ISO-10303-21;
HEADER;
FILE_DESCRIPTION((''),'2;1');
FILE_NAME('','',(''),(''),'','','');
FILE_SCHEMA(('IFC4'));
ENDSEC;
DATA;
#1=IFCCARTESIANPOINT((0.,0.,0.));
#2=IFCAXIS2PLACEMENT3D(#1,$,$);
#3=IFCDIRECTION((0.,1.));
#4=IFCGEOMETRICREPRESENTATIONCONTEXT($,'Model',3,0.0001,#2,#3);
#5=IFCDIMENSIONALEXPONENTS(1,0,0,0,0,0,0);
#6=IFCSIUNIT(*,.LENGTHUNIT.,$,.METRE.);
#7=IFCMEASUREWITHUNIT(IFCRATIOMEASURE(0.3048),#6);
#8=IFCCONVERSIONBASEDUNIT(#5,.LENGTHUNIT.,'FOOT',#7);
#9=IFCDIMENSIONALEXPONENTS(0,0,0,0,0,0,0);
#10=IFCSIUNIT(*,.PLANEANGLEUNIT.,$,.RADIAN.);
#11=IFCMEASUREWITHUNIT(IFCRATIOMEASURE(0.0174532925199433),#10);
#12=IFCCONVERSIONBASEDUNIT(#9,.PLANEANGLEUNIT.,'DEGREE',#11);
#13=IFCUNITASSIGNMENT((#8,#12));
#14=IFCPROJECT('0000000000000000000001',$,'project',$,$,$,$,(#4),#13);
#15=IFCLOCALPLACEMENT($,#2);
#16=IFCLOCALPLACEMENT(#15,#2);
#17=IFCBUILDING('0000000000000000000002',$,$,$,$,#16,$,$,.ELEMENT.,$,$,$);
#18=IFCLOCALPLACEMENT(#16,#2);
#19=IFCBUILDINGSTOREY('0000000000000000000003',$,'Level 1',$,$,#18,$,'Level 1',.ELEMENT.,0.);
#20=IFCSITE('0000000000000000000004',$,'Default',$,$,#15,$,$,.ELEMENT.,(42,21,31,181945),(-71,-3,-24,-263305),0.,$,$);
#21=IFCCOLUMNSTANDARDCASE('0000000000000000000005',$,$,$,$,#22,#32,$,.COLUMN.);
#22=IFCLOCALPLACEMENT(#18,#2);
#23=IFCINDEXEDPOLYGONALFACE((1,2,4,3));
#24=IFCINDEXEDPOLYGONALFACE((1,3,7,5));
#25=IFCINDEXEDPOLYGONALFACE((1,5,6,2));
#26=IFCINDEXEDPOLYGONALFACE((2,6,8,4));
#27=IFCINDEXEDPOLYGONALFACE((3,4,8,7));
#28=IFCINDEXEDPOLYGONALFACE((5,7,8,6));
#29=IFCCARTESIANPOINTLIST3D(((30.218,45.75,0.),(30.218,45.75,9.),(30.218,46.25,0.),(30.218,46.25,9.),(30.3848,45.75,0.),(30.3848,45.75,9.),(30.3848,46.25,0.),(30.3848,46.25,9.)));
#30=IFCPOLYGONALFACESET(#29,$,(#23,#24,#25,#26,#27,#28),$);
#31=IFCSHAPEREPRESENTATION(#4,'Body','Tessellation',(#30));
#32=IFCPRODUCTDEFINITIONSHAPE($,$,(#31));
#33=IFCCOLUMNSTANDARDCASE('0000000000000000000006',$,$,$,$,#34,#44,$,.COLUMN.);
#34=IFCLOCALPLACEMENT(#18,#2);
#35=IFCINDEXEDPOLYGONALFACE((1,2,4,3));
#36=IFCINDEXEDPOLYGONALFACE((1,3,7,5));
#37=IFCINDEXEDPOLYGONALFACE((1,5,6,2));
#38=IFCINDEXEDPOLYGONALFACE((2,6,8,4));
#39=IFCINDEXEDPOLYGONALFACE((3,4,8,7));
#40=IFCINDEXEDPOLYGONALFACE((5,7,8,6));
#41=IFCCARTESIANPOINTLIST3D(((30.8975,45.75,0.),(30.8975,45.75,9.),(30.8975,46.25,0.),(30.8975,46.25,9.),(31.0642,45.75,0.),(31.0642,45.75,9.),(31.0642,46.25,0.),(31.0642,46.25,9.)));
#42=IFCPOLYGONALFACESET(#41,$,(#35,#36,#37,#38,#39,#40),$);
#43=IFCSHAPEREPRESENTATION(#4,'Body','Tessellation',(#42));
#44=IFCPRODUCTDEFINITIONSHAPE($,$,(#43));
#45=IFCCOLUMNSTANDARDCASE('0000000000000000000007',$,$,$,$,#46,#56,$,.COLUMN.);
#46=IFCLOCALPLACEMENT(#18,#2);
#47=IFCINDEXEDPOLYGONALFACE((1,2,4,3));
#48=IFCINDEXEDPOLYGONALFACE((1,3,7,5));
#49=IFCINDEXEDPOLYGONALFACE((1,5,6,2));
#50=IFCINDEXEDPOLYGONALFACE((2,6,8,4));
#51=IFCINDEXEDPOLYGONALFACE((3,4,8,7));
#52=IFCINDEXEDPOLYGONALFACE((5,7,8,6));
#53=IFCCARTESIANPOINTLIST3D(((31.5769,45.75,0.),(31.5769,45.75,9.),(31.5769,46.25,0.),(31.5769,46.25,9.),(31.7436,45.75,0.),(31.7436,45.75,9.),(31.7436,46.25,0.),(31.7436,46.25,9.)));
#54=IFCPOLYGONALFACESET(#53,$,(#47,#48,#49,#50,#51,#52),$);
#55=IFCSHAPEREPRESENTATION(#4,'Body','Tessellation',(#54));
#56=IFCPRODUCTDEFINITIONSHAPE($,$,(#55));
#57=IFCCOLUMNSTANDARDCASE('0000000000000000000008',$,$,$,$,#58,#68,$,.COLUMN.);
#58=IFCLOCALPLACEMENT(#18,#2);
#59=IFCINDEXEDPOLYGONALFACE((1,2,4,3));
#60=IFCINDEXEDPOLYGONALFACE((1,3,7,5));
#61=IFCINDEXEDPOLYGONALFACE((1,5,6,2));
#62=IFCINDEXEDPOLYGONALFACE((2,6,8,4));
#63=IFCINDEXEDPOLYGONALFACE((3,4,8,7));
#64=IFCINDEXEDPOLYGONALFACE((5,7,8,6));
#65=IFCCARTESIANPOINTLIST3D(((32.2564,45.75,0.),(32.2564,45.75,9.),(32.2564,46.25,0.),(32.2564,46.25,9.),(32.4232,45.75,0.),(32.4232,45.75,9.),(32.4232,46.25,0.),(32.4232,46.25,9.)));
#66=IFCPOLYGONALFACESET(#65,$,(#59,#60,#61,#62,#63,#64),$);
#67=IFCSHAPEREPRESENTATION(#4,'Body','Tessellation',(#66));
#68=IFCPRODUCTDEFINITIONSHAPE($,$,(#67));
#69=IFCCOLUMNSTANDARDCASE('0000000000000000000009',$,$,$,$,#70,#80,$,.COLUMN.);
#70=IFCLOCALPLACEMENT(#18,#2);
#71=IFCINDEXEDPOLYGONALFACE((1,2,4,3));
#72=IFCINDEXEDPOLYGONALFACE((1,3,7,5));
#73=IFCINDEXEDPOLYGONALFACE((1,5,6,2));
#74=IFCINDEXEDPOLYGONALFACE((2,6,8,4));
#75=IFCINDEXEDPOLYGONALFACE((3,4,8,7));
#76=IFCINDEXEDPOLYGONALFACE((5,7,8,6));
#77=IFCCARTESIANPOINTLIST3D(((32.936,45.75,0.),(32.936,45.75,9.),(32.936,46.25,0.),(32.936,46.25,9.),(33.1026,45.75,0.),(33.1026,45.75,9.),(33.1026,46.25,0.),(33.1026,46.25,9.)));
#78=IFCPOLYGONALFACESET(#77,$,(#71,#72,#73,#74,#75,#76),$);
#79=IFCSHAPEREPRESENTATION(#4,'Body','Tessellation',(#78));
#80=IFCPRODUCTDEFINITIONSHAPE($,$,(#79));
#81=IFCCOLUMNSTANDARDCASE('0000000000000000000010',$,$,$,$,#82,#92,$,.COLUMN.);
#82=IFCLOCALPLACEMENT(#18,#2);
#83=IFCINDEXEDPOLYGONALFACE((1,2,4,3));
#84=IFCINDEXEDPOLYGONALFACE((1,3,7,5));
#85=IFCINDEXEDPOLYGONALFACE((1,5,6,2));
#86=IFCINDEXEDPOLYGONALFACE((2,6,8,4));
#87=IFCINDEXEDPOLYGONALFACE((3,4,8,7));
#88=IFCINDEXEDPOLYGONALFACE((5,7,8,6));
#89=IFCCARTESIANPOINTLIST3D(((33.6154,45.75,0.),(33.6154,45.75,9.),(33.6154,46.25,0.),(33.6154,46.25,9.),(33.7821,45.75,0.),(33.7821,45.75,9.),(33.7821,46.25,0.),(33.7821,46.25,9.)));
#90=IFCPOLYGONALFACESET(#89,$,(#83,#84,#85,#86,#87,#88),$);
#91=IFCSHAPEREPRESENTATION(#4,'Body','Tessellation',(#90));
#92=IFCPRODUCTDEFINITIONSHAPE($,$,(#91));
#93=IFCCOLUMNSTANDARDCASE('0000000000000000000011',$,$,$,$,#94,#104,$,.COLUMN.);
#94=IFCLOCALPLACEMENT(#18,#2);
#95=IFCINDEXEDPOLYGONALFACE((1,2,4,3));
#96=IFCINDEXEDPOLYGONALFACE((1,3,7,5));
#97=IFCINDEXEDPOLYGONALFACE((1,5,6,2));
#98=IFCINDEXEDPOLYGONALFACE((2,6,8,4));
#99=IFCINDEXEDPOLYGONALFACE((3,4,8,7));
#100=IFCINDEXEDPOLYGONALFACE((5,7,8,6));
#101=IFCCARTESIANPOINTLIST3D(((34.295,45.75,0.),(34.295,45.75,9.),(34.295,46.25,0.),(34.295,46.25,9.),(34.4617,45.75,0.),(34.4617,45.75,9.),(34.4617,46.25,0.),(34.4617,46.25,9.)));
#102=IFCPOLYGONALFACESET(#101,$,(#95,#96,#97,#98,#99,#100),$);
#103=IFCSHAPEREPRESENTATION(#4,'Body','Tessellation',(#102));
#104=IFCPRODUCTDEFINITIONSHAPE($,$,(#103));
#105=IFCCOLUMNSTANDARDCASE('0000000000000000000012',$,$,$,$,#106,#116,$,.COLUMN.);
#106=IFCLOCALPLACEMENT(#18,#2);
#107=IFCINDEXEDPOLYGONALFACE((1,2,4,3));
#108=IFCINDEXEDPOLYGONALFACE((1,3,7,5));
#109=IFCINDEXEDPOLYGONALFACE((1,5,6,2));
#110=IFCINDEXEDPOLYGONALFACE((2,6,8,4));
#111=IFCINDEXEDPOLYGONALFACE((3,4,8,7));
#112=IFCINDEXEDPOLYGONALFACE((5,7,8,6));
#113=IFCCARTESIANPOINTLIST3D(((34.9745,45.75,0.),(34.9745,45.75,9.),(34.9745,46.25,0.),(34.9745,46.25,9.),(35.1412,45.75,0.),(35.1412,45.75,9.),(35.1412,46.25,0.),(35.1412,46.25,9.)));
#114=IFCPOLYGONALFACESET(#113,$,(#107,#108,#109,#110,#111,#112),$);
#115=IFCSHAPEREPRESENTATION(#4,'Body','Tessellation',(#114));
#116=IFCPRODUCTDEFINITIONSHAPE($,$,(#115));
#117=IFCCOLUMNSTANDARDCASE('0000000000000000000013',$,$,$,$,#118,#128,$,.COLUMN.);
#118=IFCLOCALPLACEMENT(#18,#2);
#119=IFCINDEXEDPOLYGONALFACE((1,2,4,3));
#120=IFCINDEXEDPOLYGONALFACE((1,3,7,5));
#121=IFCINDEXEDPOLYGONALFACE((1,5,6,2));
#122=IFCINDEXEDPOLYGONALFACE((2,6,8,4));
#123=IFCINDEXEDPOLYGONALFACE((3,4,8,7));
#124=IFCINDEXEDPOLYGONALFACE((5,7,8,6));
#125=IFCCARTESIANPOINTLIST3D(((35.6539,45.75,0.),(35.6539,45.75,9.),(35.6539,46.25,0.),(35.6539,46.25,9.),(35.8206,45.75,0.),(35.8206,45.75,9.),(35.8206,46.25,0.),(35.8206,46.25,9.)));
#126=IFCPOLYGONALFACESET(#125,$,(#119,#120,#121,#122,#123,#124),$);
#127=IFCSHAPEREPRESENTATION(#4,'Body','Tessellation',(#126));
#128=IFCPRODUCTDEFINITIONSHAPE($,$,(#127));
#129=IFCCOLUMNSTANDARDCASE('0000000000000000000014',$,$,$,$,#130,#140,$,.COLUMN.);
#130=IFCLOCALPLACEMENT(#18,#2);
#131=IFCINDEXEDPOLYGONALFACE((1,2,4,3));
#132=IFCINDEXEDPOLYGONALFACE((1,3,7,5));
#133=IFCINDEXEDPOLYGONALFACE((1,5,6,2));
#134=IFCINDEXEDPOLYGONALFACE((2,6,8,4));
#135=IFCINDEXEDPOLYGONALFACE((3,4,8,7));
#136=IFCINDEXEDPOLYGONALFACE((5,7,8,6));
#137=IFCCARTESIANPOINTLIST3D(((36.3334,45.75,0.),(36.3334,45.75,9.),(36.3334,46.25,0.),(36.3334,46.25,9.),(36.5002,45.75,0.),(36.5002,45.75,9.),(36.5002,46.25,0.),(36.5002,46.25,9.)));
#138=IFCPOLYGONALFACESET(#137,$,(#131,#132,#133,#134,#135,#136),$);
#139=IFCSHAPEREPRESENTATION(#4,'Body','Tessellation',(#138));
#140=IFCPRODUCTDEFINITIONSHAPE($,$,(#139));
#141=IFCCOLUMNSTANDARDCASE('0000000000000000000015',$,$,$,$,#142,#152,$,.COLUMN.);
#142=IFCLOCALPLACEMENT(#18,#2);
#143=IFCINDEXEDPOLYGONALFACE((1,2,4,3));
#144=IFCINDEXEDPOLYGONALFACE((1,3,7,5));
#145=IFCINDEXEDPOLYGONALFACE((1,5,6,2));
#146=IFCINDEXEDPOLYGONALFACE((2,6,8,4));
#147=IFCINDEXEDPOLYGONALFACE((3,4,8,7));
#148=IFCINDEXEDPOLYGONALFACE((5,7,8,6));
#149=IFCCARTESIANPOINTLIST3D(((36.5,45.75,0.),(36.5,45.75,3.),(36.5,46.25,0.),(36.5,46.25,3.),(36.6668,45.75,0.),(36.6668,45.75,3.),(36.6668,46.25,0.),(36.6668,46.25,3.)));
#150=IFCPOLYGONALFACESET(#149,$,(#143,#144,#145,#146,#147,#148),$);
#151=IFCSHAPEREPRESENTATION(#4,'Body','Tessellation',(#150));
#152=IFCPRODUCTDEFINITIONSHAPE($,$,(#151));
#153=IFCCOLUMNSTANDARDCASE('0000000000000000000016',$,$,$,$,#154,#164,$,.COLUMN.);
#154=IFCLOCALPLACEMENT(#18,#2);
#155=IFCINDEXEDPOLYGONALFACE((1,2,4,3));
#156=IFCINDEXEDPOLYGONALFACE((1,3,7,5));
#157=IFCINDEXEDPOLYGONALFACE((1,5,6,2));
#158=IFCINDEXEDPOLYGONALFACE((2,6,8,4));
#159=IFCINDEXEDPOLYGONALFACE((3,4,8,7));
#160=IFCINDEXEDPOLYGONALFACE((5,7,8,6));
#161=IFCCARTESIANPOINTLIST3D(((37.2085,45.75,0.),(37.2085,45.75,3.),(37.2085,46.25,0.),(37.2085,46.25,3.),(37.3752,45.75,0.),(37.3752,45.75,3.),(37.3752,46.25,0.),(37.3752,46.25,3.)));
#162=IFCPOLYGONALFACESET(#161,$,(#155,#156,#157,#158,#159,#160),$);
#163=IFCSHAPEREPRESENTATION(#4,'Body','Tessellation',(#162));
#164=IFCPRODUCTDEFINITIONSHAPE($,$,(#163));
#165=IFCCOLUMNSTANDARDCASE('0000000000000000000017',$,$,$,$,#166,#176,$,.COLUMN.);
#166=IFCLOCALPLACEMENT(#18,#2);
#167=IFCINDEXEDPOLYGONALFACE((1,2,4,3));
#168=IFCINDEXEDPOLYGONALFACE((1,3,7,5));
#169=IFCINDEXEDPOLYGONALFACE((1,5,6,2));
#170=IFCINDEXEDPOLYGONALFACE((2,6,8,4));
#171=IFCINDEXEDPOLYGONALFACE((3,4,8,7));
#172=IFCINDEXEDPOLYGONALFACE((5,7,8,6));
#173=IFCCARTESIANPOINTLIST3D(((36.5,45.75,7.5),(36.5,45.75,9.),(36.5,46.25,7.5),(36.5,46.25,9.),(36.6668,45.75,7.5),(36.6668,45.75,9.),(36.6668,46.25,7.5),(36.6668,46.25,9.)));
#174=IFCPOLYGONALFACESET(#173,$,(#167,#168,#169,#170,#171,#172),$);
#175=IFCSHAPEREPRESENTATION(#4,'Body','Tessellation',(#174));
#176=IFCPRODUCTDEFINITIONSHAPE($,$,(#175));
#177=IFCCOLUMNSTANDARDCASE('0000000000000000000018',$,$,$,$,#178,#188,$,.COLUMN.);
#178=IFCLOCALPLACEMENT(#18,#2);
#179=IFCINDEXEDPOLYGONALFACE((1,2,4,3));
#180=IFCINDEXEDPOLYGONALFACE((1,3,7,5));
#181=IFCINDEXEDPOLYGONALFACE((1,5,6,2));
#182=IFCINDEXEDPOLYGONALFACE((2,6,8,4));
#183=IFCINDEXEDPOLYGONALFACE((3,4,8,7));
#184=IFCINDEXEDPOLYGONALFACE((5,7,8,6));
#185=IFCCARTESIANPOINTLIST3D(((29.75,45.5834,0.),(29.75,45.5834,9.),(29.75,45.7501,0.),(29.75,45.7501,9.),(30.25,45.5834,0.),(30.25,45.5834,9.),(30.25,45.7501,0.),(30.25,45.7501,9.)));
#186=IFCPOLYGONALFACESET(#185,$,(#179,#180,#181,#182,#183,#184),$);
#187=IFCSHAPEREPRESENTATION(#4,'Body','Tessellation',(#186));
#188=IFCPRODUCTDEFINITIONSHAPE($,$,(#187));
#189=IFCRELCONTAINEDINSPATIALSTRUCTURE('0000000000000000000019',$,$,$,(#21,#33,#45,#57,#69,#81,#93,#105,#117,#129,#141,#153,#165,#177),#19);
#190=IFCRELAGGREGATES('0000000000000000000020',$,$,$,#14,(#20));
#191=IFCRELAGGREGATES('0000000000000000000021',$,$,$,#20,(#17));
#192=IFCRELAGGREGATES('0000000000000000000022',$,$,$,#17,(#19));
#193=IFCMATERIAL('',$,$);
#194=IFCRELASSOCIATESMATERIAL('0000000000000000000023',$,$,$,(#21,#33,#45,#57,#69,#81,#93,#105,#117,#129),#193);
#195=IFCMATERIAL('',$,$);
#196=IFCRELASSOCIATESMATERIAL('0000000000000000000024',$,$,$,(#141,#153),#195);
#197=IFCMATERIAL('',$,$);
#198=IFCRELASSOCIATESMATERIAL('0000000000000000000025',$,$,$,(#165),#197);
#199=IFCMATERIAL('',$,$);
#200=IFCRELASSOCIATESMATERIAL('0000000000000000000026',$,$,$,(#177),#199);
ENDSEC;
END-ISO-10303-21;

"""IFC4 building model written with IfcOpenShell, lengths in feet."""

from ifc_helpers import new_model, entity, si_unit, converted_unit, direction, frame, origin, place, context, project, spatial, rectangle, extrude, material, element, save


model = new_model("IFC4")

# Units and contexts
model_context = context("Model", 3, precision=0.0001, world=origin(), true_north=direction((0.0, 1.0)))
ifc_project = project(units=[converted_unit("LENGTHUNIT", "FOOT", entity("IfcRatioMeasure", 0.3048), si_unit("LENGTHUNIT", "METRE"), dimensions=[1, 0, 0, 0, 0, 0, 0]), converted_unit("PLANEANGLEUNIT", "DEGREE", entity("IfcRatioMeasure", 0.0174532925199433), si_unit("PLANEANGLEUNIT", "RADIAN"), dimensions=[0, 0, 0, 0, 0, 0, 0])], contexts=[model_context])

# Site, building, storey
site_placement = place(None, origin())
site = spatial("IfcSite", under=ifc_project, at=site_placement, Name="Default", CompositionType="ELEMENT", RefLatitude=(42, 21, 31, 181945), RefLongitude=(-71, -3, -24, -263305), RefElevation=0.0)
building_placement = place(site_placement, origin())
building = spatial("IfcBuilding", under=site, at=building_placement, CompositionType="ELEMENT")
storey_placement = place(building_placement, origin())
storey = spatial("IfcBuildingStorey", under=building, at=storey_placement, Name="Level 1", LongName="Level 1", CompositionType="ELEMENT", Elevation=0.0)

# Columns
ifc_material_1 = material(Name="")
placement_1 = place(storey_placement, frame((-0.25, 46.0, 0.0)))
for number, where, z_axis, x_axis in (
    (1, (30.5514, 0.0, 0.0), (0.0, 0.0, 1.0), (1.0, 0.0, 0.0)),
    (2, (31.2309, 0.0, 0.0), (0.0, 0.0, 1.0), (1.0, 0.0, 0.0)),
    (3, (31.9103, 0.0, 0.0), (0.0, 0.0, 1.0), (1.0, 0.0, 0.0)),
    (4, (32.5898, 0.0, 0.0), (0.0, 0.0, 1.0), (1.0, 0.0, 0.0)),
    (5, (33.2693, 0.0, 0.0), (0.0, 0.0, 1.0), (1.0, 0.0, 0.0)),
    (6, (33.9488, 0.0, 0.0), (0.0, 0.0, 1.0), (1.0, 0.0, 0.0)),
    (7, (34.6283, 0.0, 0.0), (0.0, 0.0, 1.0), (1.0, 0.0, 0.0)),
    (8, (35.3078, 0.0, 0.0), (0.0, 0.0, 1.0), (1.0, 0.0, 0.0)),
    (9, (35.9873, 0.0, 0.0), (0.0, 0.0, 1.0), (1.0, 0.0, 0.0)),
    (10, (36.6668, 0.0, 0.0), (0.0, 0.0, 1.0), (1.0, 0.0, 0.0)),
):
    element("IfcColumnStandardCase", number, at=place(placement_1, frame(where, z_axis=z_axis, x_axis=x_axis)), inside=storey, material=ifc_material_1, PredefinedType="COLUMN", context=model_context, shape_type="SweptSolid", body=[
        extrude(rectangle(XDim=0.1667, YDim=0.5), origin(), (0.0, 0.0, 1.0), 9.0),
    ])
ifc_material_2 = material(Name="")
for number, where, z_axis, x_axis in (
    (11, (36.8334, 0.0, 0.0), (0.0, 0.0, 1.0), (1.0, 0.0, 0.0)),
    (12, (37.5418, 0.0, 0.0), (0.0, 0.0, 1.0), (1.0, 0.0, 0.0)),
):
    element("IfcColumnStandardCase", number, at=place(placement_1, frame(where, z_axis=z_axis, x_axis=x_axis)), inside=storey, material=ifc_material_2, PredefinedType="COLUMN", context=model_context, shape_type="SweptSolid", body=[
        extrude(rectangle(XDim=0.1667, YDim=0.5), origin(), (0.0, 0.0, 1.0), 3.0),
    ])
ifc_material_3 = material(Name="")
for number, where, z_axis, x_axis in (
    (13, (36.8334, 0.0, 7.5), (0.0, 0.0, 1.0), (1.0, 0.0, 0.0)),
):
    element("IfcColumnStandardCase", number, at=place(placement_1, frame(where, z_axis=z_axis, x_axis=x_axis)), inside=storey, material=ifc_material_3, PredefinedType="COLUMN", context=model_context, shape_type="SweptSolid", body=[
        extrude(rectangle(XDim=0.1667, YDim=0.5), origin(), (0.0, 0.0, 1.0), 1.5),
    ])
ifc_material_4 = material(Name="")
placement_2 = place(storey_placement, frame((30.0, 45.75, 0.0), z_axis=(0.0, 0.0, 1.0), x_axis=(0.0, -1.0, 0.0)))
for number, where, z_axis, x_axis in (
    (14, (0.0833, 0.0, 0.0), (0.0, 0.0, 1.0), (1.0, 0.0, 0.0)),
):
    element("IfcColumnStandardCase", number, at=place(placement_2, frame(where, z_axis=z_axis, x_axis=x_axis)), inside=storey, material=ifc_material_4, PredefinedType="COLUMN", context=model_context, shape_type="SweptSolid", body=[
        extrude(rectangle(XDim=0.1667, YDim=0.5), origin(), (0.0, 0.0, 1.0), 9.0),
    ])

save(model, "model.ifc")
